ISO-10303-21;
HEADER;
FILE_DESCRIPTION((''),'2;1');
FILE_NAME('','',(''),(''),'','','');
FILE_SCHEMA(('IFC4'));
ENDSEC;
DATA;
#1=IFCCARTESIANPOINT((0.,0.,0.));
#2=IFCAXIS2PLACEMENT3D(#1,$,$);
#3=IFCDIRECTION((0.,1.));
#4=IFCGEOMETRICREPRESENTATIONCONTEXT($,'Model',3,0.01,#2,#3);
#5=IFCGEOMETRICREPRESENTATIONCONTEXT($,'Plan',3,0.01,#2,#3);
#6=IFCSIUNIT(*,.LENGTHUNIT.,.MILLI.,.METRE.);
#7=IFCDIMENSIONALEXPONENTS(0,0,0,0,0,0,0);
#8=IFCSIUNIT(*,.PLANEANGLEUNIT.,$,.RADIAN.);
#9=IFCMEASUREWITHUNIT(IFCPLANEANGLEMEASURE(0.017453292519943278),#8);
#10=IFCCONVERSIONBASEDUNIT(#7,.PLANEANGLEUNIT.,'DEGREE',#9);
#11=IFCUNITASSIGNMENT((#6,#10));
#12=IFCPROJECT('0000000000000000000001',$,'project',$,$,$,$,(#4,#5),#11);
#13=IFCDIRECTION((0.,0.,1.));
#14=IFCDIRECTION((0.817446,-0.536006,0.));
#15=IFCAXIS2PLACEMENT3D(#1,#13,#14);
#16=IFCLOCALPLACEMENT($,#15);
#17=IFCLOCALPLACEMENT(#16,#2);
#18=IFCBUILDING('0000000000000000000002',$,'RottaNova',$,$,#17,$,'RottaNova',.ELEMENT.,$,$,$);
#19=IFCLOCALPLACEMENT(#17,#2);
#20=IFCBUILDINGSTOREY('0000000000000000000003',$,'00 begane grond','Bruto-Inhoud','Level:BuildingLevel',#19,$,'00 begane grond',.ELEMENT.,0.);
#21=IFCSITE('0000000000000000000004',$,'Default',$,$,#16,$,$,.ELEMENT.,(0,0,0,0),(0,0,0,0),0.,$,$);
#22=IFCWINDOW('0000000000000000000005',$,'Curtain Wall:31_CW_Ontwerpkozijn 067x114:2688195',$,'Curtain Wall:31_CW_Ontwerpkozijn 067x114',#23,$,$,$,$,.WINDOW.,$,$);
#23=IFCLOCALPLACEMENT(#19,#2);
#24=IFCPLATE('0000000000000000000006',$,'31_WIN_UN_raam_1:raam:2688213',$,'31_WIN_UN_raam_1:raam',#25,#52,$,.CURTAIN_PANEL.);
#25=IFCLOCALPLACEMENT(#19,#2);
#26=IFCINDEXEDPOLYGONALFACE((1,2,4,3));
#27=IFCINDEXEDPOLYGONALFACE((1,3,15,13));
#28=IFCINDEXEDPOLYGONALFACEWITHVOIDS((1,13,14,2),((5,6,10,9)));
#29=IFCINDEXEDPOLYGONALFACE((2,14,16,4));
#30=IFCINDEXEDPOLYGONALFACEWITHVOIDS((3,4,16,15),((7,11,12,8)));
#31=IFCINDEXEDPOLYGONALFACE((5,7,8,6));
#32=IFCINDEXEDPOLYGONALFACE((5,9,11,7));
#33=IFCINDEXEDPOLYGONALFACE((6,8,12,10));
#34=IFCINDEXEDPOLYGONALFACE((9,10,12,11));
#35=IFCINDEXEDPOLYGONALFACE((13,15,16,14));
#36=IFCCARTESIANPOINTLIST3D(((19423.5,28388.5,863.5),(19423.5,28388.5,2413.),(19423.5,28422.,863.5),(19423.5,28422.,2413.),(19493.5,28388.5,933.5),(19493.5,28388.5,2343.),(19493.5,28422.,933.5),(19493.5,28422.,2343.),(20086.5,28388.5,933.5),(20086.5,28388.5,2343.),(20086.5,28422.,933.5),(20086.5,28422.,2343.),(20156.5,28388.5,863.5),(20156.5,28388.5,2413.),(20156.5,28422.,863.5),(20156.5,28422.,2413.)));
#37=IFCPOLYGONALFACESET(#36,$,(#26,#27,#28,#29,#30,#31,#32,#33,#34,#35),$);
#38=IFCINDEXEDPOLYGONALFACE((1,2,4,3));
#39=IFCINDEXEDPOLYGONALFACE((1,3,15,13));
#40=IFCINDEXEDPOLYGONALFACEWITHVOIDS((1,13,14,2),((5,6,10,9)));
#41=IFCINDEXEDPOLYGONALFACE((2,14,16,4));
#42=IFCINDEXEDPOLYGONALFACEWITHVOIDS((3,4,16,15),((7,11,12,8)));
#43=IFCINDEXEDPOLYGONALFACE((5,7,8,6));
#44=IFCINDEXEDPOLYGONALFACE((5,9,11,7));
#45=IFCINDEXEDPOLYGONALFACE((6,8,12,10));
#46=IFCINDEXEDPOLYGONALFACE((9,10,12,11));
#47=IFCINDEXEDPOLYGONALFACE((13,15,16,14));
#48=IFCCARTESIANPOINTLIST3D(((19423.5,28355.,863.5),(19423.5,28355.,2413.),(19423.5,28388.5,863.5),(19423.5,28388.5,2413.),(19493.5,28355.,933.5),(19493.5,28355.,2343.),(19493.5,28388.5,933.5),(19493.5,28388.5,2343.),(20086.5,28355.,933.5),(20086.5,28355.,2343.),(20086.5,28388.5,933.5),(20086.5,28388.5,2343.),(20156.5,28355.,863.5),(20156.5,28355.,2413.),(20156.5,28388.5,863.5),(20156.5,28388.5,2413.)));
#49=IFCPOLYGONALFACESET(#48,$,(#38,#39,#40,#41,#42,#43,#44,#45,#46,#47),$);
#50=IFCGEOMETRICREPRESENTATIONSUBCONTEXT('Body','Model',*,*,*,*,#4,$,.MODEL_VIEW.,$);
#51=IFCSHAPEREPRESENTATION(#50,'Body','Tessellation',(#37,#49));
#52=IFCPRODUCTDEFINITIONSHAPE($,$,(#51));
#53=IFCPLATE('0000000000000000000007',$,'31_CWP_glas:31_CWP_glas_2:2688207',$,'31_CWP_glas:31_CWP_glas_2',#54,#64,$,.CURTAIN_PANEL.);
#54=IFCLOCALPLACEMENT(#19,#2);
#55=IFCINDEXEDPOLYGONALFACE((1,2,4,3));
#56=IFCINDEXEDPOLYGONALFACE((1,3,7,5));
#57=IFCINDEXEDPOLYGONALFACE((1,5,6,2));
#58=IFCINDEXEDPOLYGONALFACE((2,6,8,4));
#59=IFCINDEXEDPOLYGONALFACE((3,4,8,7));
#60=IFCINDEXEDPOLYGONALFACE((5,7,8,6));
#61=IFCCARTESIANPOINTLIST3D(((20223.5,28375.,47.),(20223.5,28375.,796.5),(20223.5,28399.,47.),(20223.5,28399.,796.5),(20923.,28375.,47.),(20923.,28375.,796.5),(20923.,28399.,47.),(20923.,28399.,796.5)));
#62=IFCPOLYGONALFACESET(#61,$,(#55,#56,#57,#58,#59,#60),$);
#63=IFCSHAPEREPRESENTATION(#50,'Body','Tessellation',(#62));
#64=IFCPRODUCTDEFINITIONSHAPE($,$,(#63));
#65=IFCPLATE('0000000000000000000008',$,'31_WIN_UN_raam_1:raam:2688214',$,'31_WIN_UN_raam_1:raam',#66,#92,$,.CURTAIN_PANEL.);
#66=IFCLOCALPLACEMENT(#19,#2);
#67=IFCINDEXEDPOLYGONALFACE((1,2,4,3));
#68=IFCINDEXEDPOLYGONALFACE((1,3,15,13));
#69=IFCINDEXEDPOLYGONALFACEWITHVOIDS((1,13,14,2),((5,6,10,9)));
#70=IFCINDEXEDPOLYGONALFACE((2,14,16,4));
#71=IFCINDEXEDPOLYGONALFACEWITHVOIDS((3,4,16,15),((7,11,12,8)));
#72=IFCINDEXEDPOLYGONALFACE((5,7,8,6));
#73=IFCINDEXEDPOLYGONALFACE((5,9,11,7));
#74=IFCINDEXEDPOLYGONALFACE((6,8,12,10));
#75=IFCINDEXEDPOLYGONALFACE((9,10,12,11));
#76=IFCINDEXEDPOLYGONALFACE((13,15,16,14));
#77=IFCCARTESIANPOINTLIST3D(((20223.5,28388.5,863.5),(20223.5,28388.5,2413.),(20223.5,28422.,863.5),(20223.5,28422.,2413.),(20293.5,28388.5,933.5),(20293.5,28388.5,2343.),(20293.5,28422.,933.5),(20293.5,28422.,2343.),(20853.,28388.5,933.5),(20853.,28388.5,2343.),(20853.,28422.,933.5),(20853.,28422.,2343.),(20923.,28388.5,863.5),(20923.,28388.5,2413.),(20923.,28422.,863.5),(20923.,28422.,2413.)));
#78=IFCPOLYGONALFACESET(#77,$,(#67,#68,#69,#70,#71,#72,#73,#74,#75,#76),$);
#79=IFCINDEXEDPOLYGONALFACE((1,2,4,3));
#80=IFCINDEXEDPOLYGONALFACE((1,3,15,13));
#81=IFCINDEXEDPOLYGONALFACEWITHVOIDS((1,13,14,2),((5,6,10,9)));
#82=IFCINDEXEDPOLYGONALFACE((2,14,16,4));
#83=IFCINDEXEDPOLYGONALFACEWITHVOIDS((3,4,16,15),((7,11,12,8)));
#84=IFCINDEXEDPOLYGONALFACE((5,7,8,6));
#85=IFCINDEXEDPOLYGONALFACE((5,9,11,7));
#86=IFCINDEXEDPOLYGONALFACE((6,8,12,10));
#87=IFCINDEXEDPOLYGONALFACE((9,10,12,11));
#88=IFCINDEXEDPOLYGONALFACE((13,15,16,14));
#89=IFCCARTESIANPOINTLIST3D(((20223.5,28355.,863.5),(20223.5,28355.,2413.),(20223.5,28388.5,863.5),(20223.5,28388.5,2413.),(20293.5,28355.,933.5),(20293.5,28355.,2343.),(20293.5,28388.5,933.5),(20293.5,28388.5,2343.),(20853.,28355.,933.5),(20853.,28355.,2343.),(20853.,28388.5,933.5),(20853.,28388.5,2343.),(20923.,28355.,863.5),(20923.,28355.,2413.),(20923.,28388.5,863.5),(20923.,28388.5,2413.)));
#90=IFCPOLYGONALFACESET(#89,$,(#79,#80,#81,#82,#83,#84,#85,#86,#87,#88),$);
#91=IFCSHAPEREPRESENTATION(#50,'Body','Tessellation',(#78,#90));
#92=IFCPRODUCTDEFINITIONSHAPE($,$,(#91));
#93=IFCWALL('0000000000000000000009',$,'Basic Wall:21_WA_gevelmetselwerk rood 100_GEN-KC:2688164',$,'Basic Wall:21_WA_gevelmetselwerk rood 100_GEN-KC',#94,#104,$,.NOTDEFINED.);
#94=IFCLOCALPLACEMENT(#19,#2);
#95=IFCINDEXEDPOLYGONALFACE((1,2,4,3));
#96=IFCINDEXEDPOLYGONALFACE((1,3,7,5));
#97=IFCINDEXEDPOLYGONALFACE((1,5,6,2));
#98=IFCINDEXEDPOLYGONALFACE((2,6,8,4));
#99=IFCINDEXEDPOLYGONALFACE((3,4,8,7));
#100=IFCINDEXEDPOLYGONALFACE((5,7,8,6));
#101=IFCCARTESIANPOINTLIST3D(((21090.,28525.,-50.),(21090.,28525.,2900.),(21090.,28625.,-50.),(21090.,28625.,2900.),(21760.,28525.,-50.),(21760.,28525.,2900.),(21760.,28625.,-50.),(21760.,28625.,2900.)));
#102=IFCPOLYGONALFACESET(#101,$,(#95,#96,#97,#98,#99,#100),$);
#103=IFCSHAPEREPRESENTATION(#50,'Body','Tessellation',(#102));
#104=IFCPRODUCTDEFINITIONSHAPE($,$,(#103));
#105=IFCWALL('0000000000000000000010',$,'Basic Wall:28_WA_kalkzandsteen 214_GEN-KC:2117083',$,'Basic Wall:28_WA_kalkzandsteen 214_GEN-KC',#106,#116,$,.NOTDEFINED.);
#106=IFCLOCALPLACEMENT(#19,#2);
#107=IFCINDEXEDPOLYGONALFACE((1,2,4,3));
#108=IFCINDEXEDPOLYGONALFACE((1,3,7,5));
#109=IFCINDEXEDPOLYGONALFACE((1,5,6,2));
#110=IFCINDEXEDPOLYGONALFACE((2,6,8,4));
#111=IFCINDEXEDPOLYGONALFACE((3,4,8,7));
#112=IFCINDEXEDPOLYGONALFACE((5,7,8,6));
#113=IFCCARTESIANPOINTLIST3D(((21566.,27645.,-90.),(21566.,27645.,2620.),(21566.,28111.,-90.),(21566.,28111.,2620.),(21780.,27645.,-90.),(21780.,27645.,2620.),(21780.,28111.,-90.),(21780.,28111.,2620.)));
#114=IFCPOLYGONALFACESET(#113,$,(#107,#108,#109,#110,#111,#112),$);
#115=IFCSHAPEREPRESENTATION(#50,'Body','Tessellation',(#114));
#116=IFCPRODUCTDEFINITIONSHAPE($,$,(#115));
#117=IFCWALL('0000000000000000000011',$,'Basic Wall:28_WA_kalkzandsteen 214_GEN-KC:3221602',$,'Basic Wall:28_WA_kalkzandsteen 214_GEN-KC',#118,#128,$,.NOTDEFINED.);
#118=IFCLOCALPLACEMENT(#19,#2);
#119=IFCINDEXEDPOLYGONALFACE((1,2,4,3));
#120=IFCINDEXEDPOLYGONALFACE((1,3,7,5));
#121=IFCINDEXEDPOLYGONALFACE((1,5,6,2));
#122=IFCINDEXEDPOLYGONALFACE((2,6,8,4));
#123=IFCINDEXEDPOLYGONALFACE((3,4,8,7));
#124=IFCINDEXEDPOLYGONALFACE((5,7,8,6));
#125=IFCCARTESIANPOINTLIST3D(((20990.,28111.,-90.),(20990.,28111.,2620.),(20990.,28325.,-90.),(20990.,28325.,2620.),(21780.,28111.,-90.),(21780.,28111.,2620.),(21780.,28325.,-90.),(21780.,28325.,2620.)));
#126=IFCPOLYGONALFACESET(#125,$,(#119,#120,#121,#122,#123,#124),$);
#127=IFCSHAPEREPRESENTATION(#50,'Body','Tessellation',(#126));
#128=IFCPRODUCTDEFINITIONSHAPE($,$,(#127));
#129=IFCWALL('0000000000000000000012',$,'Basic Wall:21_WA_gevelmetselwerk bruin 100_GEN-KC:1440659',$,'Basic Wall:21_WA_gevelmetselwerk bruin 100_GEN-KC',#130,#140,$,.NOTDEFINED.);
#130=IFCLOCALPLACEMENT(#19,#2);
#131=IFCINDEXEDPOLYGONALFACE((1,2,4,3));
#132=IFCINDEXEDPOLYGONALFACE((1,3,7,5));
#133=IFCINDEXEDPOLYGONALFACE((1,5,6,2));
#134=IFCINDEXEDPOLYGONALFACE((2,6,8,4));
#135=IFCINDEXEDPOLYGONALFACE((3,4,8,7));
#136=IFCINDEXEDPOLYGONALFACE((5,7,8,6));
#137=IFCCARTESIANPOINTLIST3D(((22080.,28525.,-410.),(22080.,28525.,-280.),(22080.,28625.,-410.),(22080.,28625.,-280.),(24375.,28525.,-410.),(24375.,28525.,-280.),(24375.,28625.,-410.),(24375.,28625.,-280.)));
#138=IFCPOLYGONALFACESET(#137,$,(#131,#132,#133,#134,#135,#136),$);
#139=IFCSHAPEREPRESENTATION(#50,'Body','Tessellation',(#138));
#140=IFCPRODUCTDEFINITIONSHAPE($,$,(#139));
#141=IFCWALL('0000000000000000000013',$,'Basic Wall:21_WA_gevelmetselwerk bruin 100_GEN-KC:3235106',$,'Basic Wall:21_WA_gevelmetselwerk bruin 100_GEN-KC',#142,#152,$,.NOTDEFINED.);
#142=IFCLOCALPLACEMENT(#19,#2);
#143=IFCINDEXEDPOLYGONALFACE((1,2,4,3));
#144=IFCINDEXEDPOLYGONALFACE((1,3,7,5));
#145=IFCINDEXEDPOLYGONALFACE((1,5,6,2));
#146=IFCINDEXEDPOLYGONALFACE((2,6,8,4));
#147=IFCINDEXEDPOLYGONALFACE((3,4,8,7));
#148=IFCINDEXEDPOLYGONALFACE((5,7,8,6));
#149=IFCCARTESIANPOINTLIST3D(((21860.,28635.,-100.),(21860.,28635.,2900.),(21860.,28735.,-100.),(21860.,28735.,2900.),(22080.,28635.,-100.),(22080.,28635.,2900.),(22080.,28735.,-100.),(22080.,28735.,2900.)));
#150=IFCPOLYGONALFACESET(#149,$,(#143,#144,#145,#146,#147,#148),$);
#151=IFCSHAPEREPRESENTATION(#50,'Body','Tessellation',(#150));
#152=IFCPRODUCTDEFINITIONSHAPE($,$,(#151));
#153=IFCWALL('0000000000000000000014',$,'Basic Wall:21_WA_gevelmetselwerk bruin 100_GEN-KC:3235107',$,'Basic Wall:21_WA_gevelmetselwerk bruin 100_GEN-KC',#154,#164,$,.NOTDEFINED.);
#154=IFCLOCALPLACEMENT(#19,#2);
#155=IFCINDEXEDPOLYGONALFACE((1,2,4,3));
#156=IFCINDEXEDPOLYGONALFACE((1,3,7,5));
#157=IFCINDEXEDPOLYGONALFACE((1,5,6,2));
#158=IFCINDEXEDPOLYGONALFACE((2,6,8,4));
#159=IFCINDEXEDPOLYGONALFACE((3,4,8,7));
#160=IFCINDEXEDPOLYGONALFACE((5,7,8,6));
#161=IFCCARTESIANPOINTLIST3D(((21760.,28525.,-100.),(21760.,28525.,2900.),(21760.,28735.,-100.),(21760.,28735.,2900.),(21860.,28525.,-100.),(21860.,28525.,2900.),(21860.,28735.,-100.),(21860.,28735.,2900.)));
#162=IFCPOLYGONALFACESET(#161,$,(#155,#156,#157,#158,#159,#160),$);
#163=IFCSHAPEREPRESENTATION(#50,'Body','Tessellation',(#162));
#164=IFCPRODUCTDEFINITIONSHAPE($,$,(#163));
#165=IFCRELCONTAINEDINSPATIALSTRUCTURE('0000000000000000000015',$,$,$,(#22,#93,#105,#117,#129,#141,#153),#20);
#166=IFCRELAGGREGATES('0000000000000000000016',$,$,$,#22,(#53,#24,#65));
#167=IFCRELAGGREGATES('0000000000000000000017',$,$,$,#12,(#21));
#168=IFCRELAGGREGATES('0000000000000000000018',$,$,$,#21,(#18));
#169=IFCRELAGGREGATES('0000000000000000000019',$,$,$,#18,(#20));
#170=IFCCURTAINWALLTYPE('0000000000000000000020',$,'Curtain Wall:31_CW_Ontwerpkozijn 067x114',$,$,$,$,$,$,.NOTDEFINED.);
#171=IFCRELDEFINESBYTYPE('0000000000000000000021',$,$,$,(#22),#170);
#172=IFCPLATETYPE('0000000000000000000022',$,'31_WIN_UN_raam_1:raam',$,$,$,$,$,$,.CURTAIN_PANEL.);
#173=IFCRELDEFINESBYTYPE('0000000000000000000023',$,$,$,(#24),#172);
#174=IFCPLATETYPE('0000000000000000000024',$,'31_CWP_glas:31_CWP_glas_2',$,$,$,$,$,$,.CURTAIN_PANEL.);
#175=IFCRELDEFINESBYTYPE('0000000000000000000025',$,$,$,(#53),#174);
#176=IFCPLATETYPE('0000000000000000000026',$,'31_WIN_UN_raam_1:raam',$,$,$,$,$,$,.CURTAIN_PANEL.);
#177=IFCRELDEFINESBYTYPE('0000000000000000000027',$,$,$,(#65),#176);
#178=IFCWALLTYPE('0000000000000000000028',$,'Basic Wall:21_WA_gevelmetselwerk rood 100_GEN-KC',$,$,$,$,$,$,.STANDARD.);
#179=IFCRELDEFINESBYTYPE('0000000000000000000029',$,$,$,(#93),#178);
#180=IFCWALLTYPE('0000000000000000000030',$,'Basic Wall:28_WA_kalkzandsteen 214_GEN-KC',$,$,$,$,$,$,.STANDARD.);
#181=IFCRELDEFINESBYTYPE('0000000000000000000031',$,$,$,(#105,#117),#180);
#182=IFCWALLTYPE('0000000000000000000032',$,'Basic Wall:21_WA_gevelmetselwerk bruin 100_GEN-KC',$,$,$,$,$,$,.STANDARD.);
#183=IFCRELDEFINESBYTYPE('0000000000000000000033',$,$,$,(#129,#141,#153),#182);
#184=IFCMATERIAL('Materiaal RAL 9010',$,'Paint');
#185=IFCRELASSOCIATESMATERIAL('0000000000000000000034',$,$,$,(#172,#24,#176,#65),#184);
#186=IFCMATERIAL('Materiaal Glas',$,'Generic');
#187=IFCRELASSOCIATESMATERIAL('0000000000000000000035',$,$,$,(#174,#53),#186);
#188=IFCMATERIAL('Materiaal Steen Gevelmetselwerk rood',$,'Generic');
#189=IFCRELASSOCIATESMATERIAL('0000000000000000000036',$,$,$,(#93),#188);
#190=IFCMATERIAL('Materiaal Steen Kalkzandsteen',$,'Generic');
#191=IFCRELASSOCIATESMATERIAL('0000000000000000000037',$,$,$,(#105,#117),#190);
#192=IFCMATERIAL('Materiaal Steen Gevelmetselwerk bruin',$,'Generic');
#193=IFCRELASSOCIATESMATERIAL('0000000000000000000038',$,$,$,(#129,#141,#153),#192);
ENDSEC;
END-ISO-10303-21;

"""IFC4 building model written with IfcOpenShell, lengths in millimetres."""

from ifc_helpers import new_model, entity, si_unit, converted_unit, direction, frame, origin, place, context, subcontext, project, spatial, indexed_curve, outline, extrude, source, transform, mapped, material, type_object, type_shapes, element, aggregate, save


model = new_model("IFC4")

# Units and contexts
model_context = context("Model", 3, precision=0.01, world=origin(), true_north=direction((0.0, 1.0)))
plan_context = context("Plan", 3, precision=0.01, world=origin(), true_north=direction((0.0, 1.0)))
body_context = subcontext(model_context, "Body", "Model", "MODEL_VIEW")
ifc_project = project(units=[si_unit("LENGTHUNIT", "METRE", prefix="MILLI"), converted_unit("PLANEANGLEUNIT", "DEGREE", entity("IfcPlaneAngleMeasure", 0.017453292519943278), si_unit("PLANEANGLEUNIT", "RADIAN"), dimensions=[0, 0, 0, 0, 0, 0, 0])], contexts=[model_context, plan_context])

# Site, building, storey
site_placement = place(None, frame((0.0, 0.0, 0.0), z_axis=(0.0, 0.0, 1.0), x_axis=(0.817446, -0.536006, 0.0)))
site = spatial("IfcSite", under=ifc_project, at=site_placement, Name="Default", CompositionType="ELEMENT", RefLatitude=(0, 0, 0, 0), RefLongitude=(0, 0, 0, 0), RefElevation=0.0)
building_placement = place(site_placement, origin())
building = spatial("IfcBuilding", under=site, at=building_placement, Name="RottaNova", LongName="RottaNova", CompositionType="ELEMENT")
storey_placement = place(building_placement, origin())
storey = spatial("IfcBuildingStorey", under=building, at=storey_placement, Name="00 begane grond", Description="Bruto-Inhoud", ObjectType="Level:BuildingLevel", LongName="00 begane grond", CompositionType="ELEMENT", Elevation=0.0)

# Window, plates
curtain_wall_type = type_object("IfcCurtainWallType", Name="Curtain Wall:31_CW_Ontwerpkozijn 067x114", PredefinedType="NOTDEFINED")
window_1_placement = place(storey_placement, origin())
window_1 = element("IfcWindow", 1, at=window_1_placement, inside=storey, type_object=curtain_wall_type, Name="Curtain Wall:31_CW_Ontwerpkozijn 067x114:2688195", ObjectType="Curtain Wall:31_CW_Ontwerpkozijn 067x114", PredefinedType="WINDOW")
ifc_material_1 = material(Name="Materiaal RAL 9010", Category="Paint")
plate_type_1 = type_object("IfcPlateType", Name="31_WIN_UN_raam_1:raam", PredefinedType="CURTAIN_PANEL", material=ifc_material_1)
shared_shape_1 = source(origin(), body_context, "Body", "SweptSolid", [
    extrude(outline(indexed_curve([(-366.5, -774.8), (366.5, -774.8), (366.5, 774.8), (-366.5, 774.8), (-366.5, -774.8)], self_intersect=False), holes=[indexed_curve([(-296.5, 704.8), (296.5, 704.8), (296.5, -704.8), (-296.5, -704.8), (-296.5, 704.8)], self_intersect=False)]), frame((0.0, 58.5, 774.8), z_axis=(0.0, 1.0, 0.0), x_axis=(1.0, 0.0, 0.0)), (0.0, 0.0, 1.0), 33.5),
    extrude(outline(indexed_curve([(-366.5, -774.8), (366.5, -774.8), (366.5, 774.8), (-366.5, 774.8), (-366.5, -774.8)], self_intersect=False), holes=[indexed_curve([(-296.5, 704.7), (296.5, 704.7), (296.5, -704.8), (-296.5, -704.8), (-296.5, 704.7)], self_intersect=False)]), frame((0.0, 25.0, 774.8), z_axis=(0.0, 1.0, 0.0), x_axis=(1.0, 0.0, 0.0)), (0.0, 0.0, 1.0), 33.5),
])
type_shapes(plate_type_1, [shared_shape_1])
plate_1_placement = place(window_1_placement, frame((19790.0, 28330.0, 863.5)))
plate_1 = element("IfcPlate", 2, at=plate_1_placement, type_object=plate_type_1, material=ifc_material_1, Name="31_WIN_UN_raam_1:raam:2688213", ObjectType="31_WIN_UN_raam_1:raam", PredefinedType="CURTAIN_PANEL", context=body_context, shape_type="MappedRepresentation", body=[
    mapped(shared_shape_1, transform((0.0, 0.0, 0.0), scale=1.0)),
])
ifc_material_2 = material(Name="Materiaal Glas", Category="Generic")
plate_type_2 = type_object("IfcPlateType", Name="31_CWP_glas:31_CWP_glas_2", PredefinedType="CURTAIN_PANEL", material=ifc_material_2)
shared_shape_2 = source(origin(), body_context, "Body", "SweptSolid", [
    extrude(outline(indexed_curve([(-12.0, -349.8), (12.0, -349.8), (12.0, 349.8), (-12.0, 349.8), (-12.0, -349.8)], self_intersect=False)), frame((0.0, 57.0, 0.0), z_axis=(0.0, 0.0, 1.0), x_axis=(0.0, 1.0, 0.0)), (0.0, 0.0, 1.0), 749.5),
])
type_shapes(plate_type_2, [shared_shape_2])
plate_2_placement = place(window_1_placement, frame((20573.3, 28330.0, 47.0)))
plate_2 = element("IfcPlate", 3, at=plate_2_placement, type_object=plate_type_2, material=ifc_material_2, Name="31_CWP_glas:31_CWP_glas_2:2688207", ObjectType="31_CWP_glas:31_CWP_glas_2", PredefinedType="CURTAIN_PANEL", context=body_context, shape_type="MappedRepresentation", body=[
    mapped(shared_shape_2, transform((0.0, 0.0, 0.0), scale=1.0)),
])
plate_type_3 = type_object("IfcPlateType", Name="31_WIN_UN_raam_1:raam", PredefinedType="CURTAIN_PANEL", material=ifc_material_1)
shared_shape_3 = source(origin(), body_context, "Body", "SweptSolid", [
    extrude(outline(indexed_curve([(-349.7, -774.8), (349.7, -774.8), (349.7, 774.8), (-349.7, 774.8), (-349.7, -774.8)], self_intersect=False), holes=[indexed_curve([(-279.7, 704.8), (279.7, 704.8), (279.7, -704.8), (-279.7, -704.8), (-279.7, 704.8)], self_intersect=False)]), frame((0.0, 58.5, 774.8), z_axis=(0.0, 1.0, 0.0), x_axis=(1.0, 0.0, 0.0)), (0.0, 0.0, 1.0), 33.5),
    extrude(outline(indexed_curve([(-349.7, -774.8), (349.7, -774.8), (349.7, 774.8), (-349.7, 774.8), (-349.7, -774.8)], self_intersect=False), holes=[indexed_curve([(-279.7, 704.7), (279.7, 704.7), (279.7, -704.8), (-279.7, -704.8), (-279.7, 704.7)], self_intersect=False)]), frame((0.0, 25.0, 774.8), z_axis=(0.0, 1.0, 0.0), x_axis=(1.0, 0.0, 0.0)), (0.0, 0.0, 1.0), 33.5),
])
type_shapes(plate_type_3, [shared_shape_3])
plate_3_placement = place(window_1_placement, frame((20573.3, 28330.0, 863.5)))
plate_3 = element("IfcPlate", 4, at=plate_3_placement, type_object=plate_type_3, material=ifc_material_1, Name="31_WIN_UN_raam_1:raam:2688214", ObjectType="31_WIN_UN_raam_1:raam", PredefinedType="CURTAIN_PANEL", context=body_context, shape_type="MappedRepresentation", body=[
    mapped(shared_shape_3, transform((0.0, 0.0, 0.0), scale=1.0)),
])
aggregate(window_1, [plate_2, plate_1, plate_3])

# Walls
ifc_material_3 = material(Name="Materiaal Steen Gevelmetselwerk rood", Category="Generic")
wall_type_1 = type_object("IfcWallType", Name="Basic Wall:21_WA_gevelmetselwerk rood 100_GEN-KC", PredefinedType="STANDARD")
wall_1_placement = place(storey_placement, frame((21760.0, 28575.0, -50.0), z_axis=(0.0, 0.0, 1.0), x_axis=(-1.0, 0.0, 0.0)))
element("IfcWall", 5, at=wall_1_placement, inside=storey, type_object=wall_type_1, material=ifc_material_3, Name="Basic Wall:21_WA_gevelmetselwerk rood 100_GEN-KC:2688164", ObjectType="Basic Wall:21_WA_gevelmetselwerk rood 100_GEN-KC", PredefinedType="NOTDEFINED", context=body_context, shape_type="SweptSolid", body=[
    extrude(outline(indexed_curve([(670.0, 50.0), (0.0, 50.0), (0.0, -50.0), (670.0, -50.0), (670.0, 50.0)], self_intersect=False)), origin(), (0.0, 0.0, 1.0), 2950.0),
])
ifc_material_4 = material(Name="Materiaal Steen Kalkzandsteen", Category="Generic")
wall_type_2 = type_object("IfcWallType", Name="Basic Wall:28_WA_kalkzandsteen 214_GEN-KC", PredefinedType="STANDARD")
wall_2_placement = place(storey_placement, frame((21673.0, 28111.0, -90.0), z_axis=(0.0, 0.0, 1.0), x_axis=(0.0, -1.0, 0.0)))
element("IfcWall", 6, at=wall_2_placement, inside=storey, type_object=wall_type_2, material=ifc_material_4, Name="Basic Wall:28_WA_kalkzandsteen 214_GEN-KC:2117083", ObjectType="Basic Wall:28_WA_kalkzandsteen 214_GEN-KC", PredefinedType="NOTDEFINED", context=body_context, shape_type="SweptSolid", body=[
    extrude(outline(indexed_curve([(466.0, 107.0), (0.0, 107.0), (0.0, -107.0), (466.0, -107.0), (466.0, 107.0)], self_intersect=False)), origin(), (0.0, 0.0, 1.0), 2710.0),
])
wall_3_placement = place(storey_placement, frame((20990.0, 28218.0, -90.0)))
element("IfcWall", 7, at=wall_3_placement, inside=storey, type_object=wall_type_2, material=ifc_material_4, Name="Basic Wall:28_WA_kalkzandsteen 214_GEN-KC:3221602", ObjectType="Basic Wall:28_WA_kalkzandsteen 214_GEN-KC", PredefinedType="NOTDEFINED", context=body_context, shape_type="SweptSolid", body=[
    extrude(outline(indexed_curve([(790.0, 107.0), (0.0, 107.0), (0.0, -107.0), (790.0, -107.0), (790.0, 107.0)], self_intersect=False)), origin(), (0.0, 0.0, 1.0), 2710.0),
])
ifc_material_5 = material(Name="Materiaal Steen Gevelmetselwerk bruin", Category="Generic")
wall_type_3 = type_object("IfcWallType", Name="Basic Wall:21_WA_gevelmetselwerk bruin 100_GEN-KC", PredefinedType="STANDARD")
wall_4_placement = place(storey_placement, frame((22080.0, 28575.0, -410.0)))
element("IfcWall", 8, at=wall_4_placement, inside=storey, type_object=wall_type_3, material=ifc_material_5, Name="Basic Wall:21_WA_gevelmetselwerk bruin 100_GEN-KC:1440659", ObjectType="Basic Wall:21_WA_gevelmetselwerk bruin 100_GEN-KC", PredefinedType="NOTDEFINED", context=body_context, shape_type="SweptSolid", body=[
    extrude(outline(indexed_curve([(2295.0, 50.0), (0.0, 50.0), (0.0, -50.0), (2295.0, -50.0), (2295.0, 50.0)], self_intersect=False)), origin(), (0.0, 0.0, 1.0), 130.0),
])
wall_5_placement = place(storey_placement, frame((22080.0, 28685.0, -100.0), z_axis=(0.0, 0.0, 1.0), x_axis=(-1.0, 0.0, 0.0)))
element("IfcWall", 9, at=wall_5_placement, inside=storey, type_object=wall_type_3, material=ifc_material_5, Name="Basic Wall:21_WA_gevelmetselwerk bruin 100_GEN-KC:3235106", ObjectType="Basic Wall:21_WA_gevelmetselwerk bruin 100_GEN-KC", PredefinedType="NOTDEFINED", context=body_context, shape_type="SweptSolid", body=[
    extrude(outline(indexed_curve([(220.0, 50.0), (0.0, 50.0), (0.0, -50.0), (220.0, -50.0), (220.0, 50.0)], self_intersect=False)), origin(), (0.0, 0.0, 1.0), 3000.0),
])
wall_6_placement = place(storey_placement, frame((21810.0, 28735.0, -100.0), z_axis=(0.0, 0.0, 1.0), x_axis=(0.0, -1.0, 0.0)))
element("IfcWall", 10, at=wall_6_placement, inside=storey, type_object=wall_type_3, material=ifc_material_5, Name="Basic Wall:21_WA_gevelmetselwerk bruin 100_GEN-KC:3235107", ObjectType="Basic Wall:21_WA_gevelmetselwerk bruin 100_GEN-KC", PredefinedType="NOTDEFINED", context=body_context, shape_type="SweptSolid", body=[
    extrude(outline(indexed_curve([(210.0, 50.0), (0.0, 50.0), (0.0, -50.0), (210.0, -50.0), (210.0, 50.0)], self_intersect=False)), origin(), (0.0, 0.0, 1.0), 3000.0),
])

save(model, "model.ifc")
